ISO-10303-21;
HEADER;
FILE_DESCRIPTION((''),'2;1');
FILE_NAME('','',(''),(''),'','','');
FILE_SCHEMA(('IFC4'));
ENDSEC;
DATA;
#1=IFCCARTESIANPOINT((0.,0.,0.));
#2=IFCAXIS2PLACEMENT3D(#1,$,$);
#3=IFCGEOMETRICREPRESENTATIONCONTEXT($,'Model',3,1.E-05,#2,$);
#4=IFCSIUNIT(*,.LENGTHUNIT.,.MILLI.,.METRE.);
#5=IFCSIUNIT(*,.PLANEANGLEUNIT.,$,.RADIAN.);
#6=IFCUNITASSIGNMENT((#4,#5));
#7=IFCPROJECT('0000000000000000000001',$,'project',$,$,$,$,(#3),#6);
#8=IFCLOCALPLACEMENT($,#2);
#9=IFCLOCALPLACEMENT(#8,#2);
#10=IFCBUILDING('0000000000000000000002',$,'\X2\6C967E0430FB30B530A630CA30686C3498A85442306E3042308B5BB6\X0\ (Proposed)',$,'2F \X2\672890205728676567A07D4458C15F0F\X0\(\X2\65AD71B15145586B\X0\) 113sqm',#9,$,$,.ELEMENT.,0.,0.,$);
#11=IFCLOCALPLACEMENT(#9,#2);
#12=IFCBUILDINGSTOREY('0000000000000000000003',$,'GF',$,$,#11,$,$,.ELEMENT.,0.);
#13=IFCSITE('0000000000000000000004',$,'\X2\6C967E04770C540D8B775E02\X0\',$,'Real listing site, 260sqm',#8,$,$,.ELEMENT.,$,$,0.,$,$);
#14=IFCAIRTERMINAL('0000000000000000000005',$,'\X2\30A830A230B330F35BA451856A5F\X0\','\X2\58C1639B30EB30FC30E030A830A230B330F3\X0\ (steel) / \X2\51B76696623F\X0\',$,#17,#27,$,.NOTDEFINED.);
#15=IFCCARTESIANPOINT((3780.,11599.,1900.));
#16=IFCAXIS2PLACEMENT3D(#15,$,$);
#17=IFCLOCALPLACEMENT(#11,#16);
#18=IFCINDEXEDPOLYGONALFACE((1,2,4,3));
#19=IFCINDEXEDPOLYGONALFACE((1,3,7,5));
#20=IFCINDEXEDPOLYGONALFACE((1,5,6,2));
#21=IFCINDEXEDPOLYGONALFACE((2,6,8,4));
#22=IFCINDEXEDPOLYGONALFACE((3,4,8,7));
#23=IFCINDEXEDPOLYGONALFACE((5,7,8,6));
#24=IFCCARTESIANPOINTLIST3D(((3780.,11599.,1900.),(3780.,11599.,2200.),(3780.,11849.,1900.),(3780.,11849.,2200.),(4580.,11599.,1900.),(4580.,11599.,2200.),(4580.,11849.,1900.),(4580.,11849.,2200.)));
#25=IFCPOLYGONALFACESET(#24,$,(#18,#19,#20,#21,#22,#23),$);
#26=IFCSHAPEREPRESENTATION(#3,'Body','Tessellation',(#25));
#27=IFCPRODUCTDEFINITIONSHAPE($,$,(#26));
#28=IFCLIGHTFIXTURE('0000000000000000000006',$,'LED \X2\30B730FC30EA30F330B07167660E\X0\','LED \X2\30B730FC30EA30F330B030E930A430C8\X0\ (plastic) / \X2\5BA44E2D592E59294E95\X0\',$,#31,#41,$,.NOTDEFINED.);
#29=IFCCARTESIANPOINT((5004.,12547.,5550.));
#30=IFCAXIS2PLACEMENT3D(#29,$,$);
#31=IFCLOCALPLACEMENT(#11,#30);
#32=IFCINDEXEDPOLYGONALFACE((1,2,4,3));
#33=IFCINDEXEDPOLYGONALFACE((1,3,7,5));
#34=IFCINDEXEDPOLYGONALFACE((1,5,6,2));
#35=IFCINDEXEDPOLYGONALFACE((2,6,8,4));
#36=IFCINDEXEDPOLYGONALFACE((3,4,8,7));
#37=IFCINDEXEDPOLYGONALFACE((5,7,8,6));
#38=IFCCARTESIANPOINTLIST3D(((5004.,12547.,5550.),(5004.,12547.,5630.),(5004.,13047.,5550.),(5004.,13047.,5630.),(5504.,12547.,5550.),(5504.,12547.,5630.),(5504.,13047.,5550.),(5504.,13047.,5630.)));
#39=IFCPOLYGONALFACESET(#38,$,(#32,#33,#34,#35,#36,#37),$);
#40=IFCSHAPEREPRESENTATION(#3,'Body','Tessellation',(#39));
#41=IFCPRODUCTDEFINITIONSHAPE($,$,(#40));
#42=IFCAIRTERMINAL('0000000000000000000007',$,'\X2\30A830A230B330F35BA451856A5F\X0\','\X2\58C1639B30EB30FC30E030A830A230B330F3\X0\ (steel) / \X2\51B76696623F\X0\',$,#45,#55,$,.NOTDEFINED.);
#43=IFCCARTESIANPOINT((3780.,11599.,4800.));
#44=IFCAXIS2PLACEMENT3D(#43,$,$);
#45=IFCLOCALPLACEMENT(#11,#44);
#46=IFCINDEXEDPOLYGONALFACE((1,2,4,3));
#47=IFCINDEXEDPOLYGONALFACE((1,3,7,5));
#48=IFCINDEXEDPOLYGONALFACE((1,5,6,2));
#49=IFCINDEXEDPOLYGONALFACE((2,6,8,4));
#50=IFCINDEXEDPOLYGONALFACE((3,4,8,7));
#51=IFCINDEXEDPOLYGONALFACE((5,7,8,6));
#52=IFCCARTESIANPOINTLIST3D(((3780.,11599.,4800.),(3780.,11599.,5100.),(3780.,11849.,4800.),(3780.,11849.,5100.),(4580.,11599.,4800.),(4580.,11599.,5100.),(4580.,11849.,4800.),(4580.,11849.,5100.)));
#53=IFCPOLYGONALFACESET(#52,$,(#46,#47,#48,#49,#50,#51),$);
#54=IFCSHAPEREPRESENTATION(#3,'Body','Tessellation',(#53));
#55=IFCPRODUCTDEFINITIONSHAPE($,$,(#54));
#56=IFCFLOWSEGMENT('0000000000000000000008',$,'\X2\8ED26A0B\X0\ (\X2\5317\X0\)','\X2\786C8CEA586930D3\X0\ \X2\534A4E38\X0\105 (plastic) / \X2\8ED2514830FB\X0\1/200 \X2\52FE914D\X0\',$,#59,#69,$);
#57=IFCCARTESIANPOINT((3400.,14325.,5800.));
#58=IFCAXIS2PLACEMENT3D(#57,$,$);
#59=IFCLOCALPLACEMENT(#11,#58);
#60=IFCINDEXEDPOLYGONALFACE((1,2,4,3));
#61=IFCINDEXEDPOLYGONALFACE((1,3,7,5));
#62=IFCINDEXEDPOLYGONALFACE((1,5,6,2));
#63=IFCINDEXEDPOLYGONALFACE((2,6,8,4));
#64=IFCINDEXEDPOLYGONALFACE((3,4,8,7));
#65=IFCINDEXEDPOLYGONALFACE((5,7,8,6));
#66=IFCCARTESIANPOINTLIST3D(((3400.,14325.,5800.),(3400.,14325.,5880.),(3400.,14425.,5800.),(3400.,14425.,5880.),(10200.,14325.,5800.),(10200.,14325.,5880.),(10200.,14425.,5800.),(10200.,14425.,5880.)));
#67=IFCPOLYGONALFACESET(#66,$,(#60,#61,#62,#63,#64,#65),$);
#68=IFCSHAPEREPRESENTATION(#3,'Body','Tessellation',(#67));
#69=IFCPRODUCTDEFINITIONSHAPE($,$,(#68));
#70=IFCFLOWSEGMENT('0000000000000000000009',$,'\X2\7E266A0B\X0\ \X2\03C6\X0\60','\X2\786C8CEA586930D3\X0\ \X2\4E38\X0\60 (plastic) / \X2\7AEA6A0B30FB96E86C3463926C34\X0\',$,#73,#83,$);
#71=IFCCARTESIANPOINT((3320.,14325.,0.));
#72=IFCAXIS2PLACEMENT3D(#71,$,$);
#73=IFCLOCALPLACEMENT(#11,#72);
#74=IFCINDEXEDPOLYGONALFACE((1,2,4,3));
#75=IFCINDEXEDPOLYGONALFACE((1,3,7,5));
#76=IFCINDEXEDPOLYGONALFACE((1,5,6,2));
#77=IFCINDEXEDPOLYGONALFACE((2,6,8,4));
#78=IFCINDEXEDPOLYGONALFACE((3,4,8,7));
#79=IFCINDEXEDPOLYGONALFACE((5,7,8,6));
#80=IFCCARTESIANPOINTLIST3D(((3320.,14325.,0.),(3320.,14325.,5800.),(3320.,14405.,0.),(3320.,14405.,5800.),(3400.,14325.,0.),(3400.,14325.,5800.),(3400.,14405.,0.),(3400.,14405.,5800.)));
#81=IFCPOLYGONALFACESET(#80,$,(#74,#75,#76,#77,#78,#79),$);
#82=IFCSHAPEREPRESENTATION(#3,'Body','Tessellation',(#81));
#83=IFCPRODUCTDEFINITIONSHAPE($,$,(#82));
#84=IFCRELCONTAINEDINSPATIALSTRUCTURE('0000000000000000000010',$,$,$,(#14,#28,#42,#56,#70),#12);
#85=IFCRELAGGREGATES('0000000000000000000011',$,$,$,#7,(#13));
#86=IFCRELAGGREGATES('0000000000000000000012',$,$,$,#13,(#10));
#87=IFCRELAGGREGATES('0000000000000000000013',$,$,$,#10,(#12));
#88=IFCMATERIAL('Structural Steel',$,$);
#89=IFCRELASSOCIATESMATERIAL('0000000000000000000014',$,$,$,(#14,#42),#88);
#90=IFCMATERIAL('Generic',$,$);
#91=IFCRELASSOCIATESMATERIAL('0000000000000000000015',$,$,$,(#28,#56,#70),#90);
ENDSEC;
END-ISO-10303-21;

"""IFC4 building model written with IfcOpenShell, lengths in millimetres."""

from ifc_helpers import new_model, si_unit, frame, frame_2d, origin, place, context, project, spatial, rectangle, extrude, material, element, save


model = new_model("IFC4")

# Units and contexts
model_context = context("Model", 3, precision=1e-05, world=origin())
ifc_project = project(units=[si_unit("LENGTHUNIT", "METRE", prefix="MILLI"), si_unit("PLANEANGLEUNIT", "RADIAN")], contexts=[model_context])

# Site, building, storey
site_placement = place(None, origin())
site = spatial("IfcSite", under=ifc_project, at=site_placement, Name="沖縄県名護市", ObjectType="Real listing site, 260sqm", CompositionType="ELEMENT", RefElevation=0.0)
building_placement = place(site_placement, origin())
building = spatial("IfcBuilding", under=site, at=building_placement, Name="沖縄・サウナと水風呂のある家 (Proposed)", ObjectType="2F 木造在来枠組壁式(断熱充填) 113sqm", CompositionType="ELEMENT", ElevationOfRefHeight=0.0, ElevationOfTerrain=0.0)
storey_placement = place(building_placement, origin())
storey = spatial("IfcBuildingStorey", under=building, at=storey_placement, Name="GF", CompositionType="ELEMENT", Elevation=0.0)

# Shared definitions
ifc_material_1 = material(Name="Generic")

# Shared definitions
ifc_material_2 = material(Name="Structural Steel")

# Air terminal
air_terminal_1_placement = place(storey_placement, frame((3780.0, 11599.0, 1900.0)))
element("IfcAirTerminal", 1, at=air_terminal_1_placement, inside=storey, material=ifc_material_2, Name="エアコン室内機", Description="壁掛ルームエアコン (steel) / 冷暖房", PredefinedType="NOTDEFINED", context=model_context, shape_type="SweptSolid", body=[
    extrude(rectangle(XDim=800.0, YDim=250.0, at=frame_2d((400.0, 125.0))), frame((3780.0, 11599.0, 1900.0)), (0.0, 0.0, 1.0), 300.0),
])

# Light fixture
light_fixture_placement = place(storey_placement, frame((5004.0, 12547.0, 5550.0)))
element("IfcLightFixture", 2, at=light_fixture_placement, inside=storey, material=ifc_material_1, Name="LED シーリング照明", Description="LED シーリングライト (plastic) / 室中央天井", PredefinedType="NOTDEFINED", context=model_context, shape_type="SweptSolid", body=[
    extrude(rectangle(XDim=500.0, YDim=500.0, at=frame_2d((250.0, 250.0))), frame((5004.0, 12547.0, 5550.0)), (0.0, 0.0, 1.0), 80.0),
])

# Air terminal
air_terminal_2_placement = place(storey_placement, frame((3780.0, 11599.0, 4800.0)))
element("IfcAirTerminal", 3, at=air_terminal_2_placement, inside=storey, material=ifc_material_2, Name="エアコン室内機", Description="壁掛ルームエアコン (steel) / 冷暖房", PredefinedType="NOTDEFINED", context=model_context, shape_type="SweptSolid", body=[
    extrude(rectangle(XDim=800.0, YDim=250.0, at=frame_2d((400.0, 125.0))), frame((3780.0, 11599.0, 4800.0)), (0.0, 0.0, 1.0), 300.0),
])

# Flow segments
flow_segment_1_placement = place(storey_placement, frame((3400.0, 14325.0, 5800.0)))
element("IfcFlowSegment", 4, at=flow_segment_1_placement, inside=storey, material=ifc_material_1, Name="軒樋 (北)", Description="硬質塩ビ 半丸105 (plastic) / 軒先・1/200 勾配", context=model_context, shape_type="SweptSolid", body=[
    extrude(rectangle(XDim=6800.0, YDim=100.0, at=frame_2d((3400.0, 50.0))), frame((3400.0, 14325.0, 5800.0)), (0.0, 0.0, 1.0), 80.0),
])
flow_segment_2_placement = place(storey_placement, frame((3320.0, 14325.0, 0.0)))
element("IfcFlowSegment", 5, at=flow_segment_2_placement, inside=storey, material=ifc_material_1, Name="縦樋 φ60", Description="硬質塩ビ 丸60 (plastic) / 竪樋・雨水排水", context=model_context, shape_type="SweptSolid", body=[
    extrude(rectangle(XDim=80.0, YDim=80.0, at=frame_2d((40.0, 40.0))), frame((3320.0, 14325.0, 0.0)), (0.0, 0.0, 1.0), 5800.0),
])

save(model, "model.ifc")
